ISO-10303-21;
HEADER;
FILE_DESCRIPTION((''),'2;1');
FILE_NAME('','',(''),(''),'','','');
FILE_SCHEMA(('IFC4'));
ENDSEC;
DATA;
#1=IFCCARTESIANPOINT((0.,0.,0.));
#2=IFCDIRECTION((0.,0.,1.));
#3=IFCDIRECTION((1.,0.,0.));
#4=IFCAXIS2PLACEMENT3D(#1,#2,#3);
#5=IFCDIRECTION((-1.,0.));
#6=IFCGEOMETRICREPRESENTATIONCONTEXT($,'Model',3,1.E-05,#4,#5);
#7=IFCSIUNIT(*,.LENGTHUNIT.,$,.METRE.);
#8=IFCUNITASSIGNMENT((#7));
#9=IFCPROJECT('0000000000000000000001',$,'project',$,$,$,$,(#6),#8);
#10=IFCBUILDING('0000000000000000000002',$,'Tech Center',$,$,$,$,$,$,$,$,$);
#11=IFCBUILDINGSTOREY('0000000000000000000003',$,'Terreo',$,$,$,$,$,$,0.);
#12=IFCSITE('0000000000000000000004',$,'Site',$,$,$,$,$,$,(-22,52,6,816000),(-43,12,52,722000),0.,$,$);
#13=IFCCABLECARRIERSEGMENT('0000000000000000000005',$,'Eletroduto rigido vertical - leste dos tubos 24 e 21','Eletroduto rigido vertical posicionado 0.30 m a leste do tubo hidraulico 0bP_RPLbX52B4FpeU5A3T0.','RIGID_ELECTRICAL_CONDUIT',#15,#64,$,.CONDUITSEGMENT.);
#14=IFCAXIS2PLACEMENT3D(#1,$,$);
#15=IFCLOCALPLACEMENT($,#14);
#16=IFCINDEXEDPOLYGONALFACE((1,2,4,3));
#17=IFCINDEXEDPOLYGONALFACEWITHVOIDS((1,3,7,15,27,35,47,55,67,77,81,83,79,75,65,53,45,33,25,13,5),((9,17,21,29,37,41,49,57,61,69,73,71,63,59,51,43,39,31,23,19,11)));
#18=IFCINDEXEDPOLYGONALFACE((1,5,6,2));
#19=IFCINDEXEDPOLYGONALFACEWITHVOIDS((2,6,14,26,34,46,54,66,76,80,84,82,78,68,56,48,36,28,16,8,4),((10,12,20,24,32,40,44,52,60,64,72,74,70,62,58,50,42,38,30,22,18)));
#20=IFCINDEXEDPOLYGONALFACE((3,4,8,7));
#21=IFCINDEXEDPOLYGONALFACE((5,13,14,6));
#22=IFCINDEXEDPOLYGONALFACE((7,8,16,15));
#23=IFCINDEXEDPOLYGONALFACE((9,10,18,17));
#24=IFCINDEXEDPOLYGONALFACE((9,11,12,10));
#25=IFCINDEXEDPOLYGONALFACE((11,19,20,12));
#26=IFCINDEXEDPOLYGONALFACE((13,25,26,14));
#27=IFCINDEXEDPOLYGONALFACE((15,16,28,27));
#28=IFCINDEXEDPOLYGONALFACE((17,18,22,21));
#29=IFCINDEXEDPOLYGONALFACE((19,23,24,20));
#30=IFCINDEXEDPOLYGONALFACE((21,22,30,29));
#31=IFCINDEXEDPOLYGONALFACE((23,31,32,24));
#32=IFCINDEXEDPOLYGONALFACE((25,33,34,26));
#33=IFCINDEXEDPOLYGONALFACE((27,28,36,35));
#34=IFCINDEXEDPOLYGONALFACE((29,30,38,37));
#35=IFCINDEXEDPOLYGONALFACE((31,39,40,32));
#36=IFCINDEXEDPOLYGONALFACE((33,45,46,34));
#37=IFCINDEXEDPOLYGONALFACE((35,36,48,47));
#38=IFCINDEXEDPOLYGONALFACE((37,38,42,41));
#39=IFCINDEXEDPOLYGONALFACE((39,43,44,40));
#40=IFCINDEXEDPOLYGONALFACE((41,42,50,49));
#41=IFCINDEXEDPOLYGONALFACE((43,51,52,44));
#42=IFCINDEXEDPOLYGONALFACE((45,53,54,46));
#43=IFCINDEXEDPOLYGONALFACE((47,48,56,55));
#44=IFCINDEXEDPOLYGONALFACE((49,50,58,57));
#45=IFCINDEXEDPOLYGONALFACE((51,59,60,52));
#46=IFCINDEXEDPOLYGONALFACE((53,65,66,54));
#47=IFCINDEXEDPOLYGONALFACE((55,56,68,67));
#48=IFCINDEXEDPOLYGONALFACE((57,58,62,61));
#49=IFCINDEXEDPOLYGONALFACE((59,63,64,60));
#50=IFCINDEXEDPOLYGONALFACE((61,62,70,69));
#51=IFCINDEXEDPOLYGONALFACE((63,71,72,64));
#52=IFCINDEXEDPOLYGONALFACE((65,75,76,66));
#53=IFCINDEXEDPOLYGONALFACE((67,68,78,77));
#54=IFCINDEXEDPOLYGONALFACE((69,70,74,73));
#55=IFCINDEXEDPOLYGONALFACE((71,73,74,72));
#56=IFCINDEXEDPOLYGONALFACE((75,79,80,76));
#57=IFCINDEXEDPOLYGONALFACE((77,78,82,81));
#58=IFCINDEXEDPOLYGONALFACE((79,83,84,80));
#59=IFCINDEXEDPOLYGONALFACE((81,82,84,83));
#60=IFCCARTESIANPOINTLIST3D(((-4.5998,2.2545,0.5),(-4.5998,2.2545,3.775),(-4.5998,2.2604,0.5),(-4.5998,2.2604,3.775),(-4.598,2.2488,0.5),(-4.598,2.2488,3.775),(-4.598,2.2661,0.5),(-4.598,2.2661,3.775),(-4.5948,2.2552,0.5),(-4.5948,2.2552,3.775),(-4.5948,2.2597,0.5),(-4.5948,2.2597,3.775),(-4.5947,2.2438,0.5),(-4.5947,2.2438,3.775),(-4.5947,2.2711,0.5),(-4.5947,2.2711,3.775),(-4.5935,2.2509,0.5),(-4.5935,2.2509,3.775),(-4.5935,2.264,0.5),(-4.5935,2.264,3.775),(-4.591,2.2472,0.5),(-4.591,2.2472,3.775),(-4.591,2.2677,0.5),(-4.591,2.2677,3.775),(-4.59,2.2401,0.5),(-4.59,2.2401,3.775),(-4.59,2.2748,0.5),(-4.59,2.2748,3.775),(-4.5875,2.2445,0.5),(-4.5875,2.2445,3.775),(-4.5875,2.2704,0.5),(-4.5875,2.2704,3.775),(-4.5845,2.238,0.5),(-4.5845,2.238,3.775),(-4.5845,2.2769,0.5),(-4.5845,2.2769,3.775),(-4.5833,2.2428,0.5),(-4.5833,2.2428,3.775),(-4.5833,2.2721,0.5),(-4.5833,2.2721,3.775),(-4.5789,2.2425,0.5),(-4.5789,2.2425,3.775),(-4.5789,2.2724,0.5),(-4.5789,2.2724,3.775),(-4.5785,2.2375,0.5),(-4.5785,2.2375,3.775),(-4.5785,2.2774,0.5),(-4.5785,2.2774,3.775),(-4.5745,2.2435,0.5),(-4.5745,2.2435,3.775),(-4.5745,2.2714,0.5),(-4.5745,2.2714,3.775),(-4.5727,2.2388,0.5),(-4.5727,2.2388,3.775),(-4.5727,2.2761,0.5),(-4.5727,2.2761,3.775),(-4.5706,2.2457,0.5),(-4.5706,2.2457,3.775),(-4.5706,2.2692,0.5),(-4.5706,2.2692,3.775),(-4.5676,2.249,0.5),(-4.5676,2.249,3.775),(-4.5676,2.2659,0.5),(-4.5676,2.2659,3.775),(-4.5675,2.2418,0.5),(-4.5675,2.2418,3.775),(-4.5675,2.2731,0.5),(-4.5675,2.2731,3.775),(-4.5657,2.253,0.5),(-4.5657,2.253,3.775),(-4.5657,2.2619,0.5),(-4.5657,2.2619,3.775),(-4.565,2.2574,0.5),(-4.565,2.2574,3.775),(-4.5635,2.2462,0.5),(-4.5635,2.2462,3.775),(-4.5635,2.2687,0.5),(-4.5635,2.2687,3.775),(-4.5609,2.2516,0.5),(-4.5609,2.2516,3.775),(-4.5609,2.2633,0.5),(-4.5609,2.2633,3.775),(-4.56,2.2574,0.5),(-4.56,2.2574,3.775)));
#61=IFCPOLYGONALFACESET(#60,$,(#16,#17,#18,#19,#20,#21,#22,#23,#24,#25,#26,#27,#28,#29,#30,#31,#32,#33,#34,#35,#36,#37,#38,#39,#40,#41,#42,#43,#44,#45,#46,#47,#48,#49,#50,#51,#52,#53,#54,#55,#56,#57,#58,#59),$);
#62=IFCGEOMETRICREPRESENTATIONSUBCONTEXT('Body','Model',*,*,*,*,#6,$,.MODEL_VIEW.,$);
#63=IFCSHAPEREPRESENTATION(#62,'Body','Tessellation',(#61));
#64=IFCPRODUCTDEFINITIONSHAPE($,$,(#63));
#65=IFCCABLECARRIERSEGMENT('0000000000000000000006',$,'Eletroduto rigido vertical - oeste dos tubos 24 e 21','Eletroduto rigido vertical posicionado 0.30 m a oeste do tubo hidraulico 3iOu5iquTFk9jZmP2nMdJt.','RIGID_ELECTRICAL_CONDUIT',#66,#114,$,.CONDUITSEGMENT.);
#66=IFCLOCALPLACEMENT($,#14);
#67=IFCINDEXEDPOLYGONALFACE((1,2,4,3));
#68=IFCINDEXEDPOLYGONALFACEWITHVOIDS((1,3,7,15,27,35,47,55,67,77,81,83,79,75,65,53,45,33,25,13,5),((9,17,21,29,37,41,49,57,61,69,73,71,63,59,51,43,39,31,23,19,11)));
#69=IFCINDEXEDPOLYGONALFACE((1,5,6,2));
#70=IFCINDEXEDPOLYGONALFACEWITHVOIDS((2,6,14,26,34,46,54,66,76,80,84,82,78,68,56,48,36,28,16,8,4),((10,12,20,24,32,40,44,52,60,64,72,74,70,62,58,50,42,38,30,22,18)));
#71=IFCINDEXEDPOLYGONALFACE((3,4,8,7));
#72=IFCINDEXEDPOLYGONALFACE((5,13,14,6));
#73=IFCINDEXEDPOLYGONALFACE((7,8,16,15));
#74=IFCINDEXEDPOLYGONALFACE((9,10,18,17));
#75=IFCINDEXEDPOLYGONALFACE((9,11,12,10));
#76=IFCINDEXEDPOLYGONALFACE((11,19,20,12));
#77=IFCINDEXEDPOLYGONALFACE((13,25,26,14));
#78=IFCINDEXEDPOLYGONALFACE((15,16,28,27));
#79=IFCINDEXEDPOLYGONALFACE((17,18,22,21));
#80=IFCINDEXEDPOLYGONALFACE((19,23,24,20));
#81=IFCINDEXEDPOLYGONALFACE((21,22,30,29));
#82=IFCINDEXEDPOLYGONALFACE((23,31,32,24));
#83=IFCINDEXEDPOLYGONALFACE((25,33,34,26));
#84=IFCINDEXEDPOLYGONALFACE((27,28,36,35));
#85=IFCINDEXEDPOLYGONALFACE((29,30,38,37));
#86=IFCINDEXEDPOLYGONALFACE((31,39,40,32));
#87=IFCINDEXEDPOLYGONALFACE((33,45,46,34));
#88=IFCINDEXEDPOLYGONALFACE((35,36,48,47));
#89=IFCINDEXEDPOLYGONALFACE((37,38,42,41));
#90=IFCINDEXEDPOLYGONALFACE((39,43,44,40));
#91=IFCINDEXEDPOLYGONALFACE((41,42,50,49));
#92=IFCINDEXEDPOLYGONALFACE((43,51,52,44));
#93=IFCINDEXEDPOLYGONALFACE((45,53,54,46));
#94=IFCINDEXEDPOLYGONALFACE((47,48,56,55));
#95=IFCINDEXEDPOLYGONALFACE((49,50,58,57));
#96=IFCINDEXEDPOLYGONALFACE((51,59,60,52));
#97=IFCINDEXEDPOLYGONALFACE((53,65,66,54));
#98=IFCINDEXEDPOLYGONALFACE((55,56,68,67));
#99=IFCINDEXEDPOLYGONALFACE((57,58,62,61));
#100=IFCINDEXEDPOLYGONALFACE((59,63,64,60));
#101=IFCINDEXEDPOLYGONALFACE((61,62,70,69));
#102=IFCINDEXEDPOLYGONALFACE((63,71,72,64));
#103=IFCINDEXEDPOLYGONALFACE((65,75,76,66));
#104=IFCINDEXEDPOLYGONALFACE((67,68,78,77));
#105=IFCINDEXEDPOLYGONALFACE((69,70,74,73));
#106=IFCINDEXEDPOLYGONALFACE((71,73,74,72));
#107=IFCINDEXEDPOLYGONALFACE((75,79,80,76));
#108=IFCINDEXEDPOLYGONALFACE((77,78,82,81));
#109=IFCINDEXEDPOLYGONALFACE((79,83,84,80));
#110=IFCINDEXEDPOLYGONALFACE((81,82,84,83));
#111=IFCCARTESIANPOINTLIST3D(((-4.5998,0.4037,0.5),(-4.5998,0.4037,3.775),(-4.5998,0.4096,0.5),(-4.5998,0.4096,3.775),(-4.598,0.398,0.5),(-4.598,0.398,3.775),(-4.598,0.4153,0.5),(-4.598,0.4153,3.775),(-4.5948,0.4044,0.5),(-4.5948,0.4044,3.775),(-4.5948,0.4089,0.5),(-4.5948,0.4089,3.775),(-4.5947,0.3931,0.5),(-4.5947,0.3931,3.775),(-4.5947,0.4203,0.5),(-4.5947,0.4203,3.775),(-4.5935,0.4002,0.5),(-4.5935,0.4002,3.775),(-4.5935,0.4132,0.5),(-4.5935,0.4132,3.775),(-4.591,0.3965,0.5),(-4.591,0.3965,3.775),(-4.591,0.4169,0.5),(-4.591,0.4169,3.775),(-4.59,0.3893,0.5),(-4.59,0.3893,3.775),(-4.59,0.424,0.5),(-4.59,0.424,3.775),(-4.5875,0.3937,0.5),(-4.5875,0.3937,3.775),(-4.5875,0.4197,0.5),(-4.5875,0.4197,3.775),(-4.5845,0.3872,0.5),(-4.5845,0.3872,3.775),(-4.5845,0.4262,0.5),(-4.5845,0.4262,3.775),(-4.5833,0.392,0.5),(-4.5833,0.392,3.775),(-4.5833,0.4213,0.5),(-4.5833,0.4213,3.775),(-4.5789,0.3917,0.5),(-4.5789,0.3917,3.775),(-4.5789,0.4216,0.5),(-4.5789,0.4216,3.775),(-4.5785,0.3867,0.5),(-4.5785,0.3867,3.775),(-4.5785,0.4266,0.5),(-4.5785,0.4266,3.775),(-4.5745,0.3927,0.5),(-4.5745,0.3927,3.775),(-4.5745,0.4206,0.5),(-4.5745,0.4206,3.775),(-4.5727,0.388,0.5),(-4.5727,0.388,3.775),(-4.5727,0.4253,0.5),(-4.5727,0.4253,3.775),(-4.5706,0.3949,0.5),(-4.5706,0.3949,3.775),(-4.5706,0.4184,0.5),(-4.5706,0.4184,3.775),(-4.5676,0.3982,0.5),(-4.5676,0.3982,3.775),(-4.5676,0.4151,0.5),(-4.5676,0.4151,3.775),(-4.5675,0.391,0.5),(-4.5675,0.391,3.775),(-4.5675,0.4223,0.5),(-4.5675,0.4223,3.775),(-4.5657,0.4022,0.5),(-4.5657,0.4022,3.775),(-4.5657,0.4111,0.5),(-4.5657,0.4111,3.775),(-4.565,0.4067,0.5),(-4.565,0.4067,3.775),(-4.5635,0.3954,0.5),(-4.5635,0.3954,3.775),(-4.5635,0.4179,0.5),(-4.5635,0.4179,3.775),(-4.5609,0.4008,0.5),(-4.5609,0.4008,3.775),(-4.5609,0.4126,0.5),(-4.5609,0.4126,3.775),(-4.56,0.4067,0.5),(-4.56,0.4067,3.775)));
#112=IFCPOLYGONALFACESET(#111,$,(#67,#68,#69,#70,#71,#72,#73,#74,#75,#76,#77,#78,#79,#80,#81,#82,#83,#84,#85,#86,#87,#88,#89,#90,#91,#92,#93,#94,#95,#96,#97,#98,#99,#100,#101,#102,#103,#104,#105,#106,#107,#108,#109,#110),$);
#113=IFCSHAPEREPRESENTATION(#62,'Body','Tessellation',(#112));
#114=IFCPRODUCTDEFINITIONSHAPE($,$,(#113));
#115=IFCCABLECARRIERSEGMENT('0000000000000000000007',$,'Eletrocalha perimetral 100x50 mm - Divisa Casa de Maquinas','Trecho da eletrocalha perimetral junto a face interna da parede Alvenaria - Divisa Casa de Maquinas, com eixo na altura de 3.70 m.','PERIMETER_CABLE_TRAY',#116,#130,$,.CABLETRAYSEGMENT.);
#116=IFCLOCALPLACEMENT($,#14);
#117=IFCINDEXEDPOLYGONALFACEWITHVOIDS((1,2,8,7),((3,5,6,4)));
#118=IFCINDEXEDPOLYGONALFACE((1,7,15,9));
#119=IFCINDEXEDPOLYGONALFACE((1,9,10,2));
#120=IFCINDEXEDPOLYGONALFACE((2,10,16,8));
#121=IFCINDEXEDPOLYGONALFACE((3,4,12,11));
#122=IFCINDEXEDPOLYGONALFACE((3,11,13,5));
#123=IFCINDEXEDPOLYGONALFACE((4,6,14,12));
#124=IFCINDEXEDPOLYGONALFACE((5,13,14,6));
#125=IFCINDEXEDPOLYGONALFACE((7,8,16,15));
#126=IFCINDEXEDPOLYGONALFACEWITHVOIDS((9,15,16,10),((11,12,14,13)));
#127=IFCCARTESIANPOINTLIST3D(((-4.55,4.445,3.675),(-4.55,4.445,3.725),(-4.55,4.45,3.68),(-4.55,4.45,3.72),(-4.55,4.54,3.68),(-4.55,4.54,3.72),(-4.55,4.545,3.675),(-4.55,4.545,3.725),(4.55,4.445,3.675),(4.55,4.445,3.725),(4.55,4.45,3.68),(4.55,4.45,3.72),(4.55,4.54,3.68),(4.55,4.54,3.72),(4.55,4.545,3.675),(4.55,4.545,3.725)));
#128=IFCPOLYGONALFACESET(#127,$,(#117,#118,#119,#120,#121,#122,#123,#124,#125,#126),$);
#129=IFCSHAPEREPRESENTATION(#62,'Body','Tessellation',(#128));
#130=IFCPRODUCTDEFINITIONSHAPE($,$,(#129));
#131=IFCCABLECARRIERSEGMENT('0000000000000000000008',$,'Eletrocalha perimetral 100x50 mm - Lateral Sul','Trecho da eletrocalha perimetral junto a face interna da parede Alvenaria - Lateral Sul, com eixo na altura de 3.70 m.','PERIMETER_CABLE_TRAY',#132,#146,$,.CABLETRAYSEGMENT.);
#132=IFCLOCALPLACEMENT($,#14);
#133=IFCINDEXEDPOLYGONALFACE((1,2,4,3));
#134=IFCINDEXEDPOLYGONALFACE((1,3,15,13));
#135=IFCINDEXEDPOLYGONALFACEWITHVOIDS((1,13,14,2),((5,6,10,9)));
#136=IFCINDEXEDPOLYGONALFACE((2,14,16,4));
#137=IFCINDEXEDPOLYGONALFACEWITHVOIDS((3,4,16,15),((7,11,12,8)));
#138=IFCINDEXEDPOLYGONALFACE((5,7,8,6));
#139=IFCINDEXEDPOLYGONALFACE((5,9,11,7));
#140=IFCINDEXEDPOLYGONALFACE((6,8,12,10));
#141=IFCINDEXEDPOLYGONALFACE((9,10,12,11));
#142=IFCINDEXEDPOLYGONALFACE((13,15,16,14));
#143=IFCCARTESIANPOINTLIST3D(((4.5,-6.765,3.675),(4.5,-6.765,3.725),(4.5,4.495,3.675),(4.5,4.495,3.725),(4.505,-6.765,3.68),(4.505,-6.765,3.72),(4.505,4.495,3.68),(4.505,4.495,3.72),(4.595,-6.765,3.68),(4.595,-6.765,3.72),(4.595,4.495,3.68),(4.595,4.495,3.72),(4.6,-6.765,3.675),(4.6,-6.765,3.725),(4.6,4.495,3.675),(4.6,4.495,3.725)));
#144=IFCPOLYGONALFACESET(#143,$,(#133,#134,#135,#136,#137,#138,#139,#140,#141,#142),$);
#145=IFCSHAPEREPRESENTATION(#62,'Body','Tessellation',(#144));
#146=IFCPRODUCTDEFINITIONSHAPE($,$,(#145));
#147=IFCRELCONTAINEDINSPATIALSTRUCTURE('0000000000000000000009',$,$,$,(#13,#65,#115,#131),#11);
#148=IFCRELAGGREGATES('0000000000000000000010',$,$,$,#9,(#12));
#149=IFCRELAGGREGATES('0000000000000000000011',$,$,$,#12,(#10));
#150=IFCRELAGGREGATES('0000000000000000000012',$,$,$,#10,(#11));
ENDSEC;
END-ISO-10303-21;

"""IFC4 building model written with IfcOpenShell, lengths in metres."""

from ifc_helpers import new_model, si_unit, direction, frame, origin_with_axes, place, context, subcontext, project, spatial, hollow_rectangle, hollow_circle, extrude, element, save


model = new_model("IFC4")

# Units and contexts
model_context = context("Model", 3, precision=1e-05, world=origin_with_axes(), true_north=direction((-1.0, 0.0)))
body_context = subcontext(model_context, "Body", "Model", "MODEL_VIEW")
ifc_project = project(units=[si_unit("LENGTHUNIT", "METRE")], contexts=[model_context])

# Site, building, storey
site = spatial("IfcSite", under=ifc_project, Name="Site", RefLatitude=(-22, 52, 6, 816000), RefLongitude=(-43, 12, 52, 722000), RefElevation=0.0)
building = spatial("IfcBuilding", under=site, Name="Tech Center")
storey = spatial("IfcBuildingStorey", under=building, Name="Terreo", Elevation=0.0)

# Cable carrier segments
for number, where, name, description in (
    (1, (-4.58, 2.2574, 0.5), "Eletroduto rigido vertical - leste dos tubos 24 e 21", "Eletroduto rigido vertical posicionado 0.30 m a leste do tubo hidraulico 0bP_RPLbX52B4FpeU5A3T0."),
    (2, (-4.58, 0.4067, 0.5), "Eletroduto rigido vertical - oeste dos tubos 24 e 21", "Eletroduto rigido vertical posicionado 0.30 m a oeste do tubo hidraulico 3iOu5iquTFk9jZmP2nMdJt."),
):
    element("IfcCableCarrierSegment", number, at=place(None, frame(where)), inside=storey, Name=name, Description=description, ObjectType="RIGID_ELECTRICAL_CONDUIT", PredefinedType="CONDUITSEGMENT", context=body_context, shape_type="SweptSolid", body=[
        extrude(hollow_circle(Radius=0.02, WallThickness=0.005), origin_with_axes(), (0.0, 0.0, 1.0), 3.275),
    ])
cable_carrier_segment_1_placement = place(None, frame((-4.55, 4.495, 3.7)))
element("IfcCableCarrierSegment", 3, at=cable_carrier_segment_1_placement, inside=storey, Name="Eletrocalha perimetral 100x50 mm - Divisa Casa de Maquinas", Description="Trecho da eletrocalha perimetral junto a face interna da parede Alvenaria - Divisa Casa de Maquinas, com eixo na altura de 3.70 m.", ObjectType="PERIMETER_CABLE_TRAY", PredefinedType="CABLETRAYSEGMENT", context=body_context, shape_type="SweptSolid", body=[
    extrude(hollow_rectangle(XDim=0.1, YDim=0.05, WallThickness=0.005), frame((0.0, 0.0, 0.0), z_axis=(1.0, 0.0, 0.0), x_axis=(0.0, 1.0, 0.0)), (0.0, 0.0, 1.0), 9.1),
])
cable_carrier_segment_2_placement = place(None, frame((4.55, 4.495, 3.7)))
element("IfcCableCarrierSegment", 4, at=cable_carrier_segment_2_placement, inside=storey, Name="Eletrocalha perimetral 100x50 mm - Lateral Sul", Description="Trecho da eletrocalha perimetral junto a face interna da parede Alvenaria - Lateral Sul, com eixo na altura de 3.70 m.", ObjectType="PERIMETER_CABLE_TRAY", PredefinedType="CABLETRAYSEGMENT", context=body_context, shape_type="SweptSolid", body=[
    extrude(hollow_rectangle(XDim=0.1, YDim=0.05, WallThickness=0.005), frame((0.0, 0.0, 0.0), z_axis=(0.0, -1.0, 0.0), x_axis=(1.0, 0.0, 0.0)), (0.0, 0.0, 1.0), 11.26),
])

save(model, "model.ifc")
